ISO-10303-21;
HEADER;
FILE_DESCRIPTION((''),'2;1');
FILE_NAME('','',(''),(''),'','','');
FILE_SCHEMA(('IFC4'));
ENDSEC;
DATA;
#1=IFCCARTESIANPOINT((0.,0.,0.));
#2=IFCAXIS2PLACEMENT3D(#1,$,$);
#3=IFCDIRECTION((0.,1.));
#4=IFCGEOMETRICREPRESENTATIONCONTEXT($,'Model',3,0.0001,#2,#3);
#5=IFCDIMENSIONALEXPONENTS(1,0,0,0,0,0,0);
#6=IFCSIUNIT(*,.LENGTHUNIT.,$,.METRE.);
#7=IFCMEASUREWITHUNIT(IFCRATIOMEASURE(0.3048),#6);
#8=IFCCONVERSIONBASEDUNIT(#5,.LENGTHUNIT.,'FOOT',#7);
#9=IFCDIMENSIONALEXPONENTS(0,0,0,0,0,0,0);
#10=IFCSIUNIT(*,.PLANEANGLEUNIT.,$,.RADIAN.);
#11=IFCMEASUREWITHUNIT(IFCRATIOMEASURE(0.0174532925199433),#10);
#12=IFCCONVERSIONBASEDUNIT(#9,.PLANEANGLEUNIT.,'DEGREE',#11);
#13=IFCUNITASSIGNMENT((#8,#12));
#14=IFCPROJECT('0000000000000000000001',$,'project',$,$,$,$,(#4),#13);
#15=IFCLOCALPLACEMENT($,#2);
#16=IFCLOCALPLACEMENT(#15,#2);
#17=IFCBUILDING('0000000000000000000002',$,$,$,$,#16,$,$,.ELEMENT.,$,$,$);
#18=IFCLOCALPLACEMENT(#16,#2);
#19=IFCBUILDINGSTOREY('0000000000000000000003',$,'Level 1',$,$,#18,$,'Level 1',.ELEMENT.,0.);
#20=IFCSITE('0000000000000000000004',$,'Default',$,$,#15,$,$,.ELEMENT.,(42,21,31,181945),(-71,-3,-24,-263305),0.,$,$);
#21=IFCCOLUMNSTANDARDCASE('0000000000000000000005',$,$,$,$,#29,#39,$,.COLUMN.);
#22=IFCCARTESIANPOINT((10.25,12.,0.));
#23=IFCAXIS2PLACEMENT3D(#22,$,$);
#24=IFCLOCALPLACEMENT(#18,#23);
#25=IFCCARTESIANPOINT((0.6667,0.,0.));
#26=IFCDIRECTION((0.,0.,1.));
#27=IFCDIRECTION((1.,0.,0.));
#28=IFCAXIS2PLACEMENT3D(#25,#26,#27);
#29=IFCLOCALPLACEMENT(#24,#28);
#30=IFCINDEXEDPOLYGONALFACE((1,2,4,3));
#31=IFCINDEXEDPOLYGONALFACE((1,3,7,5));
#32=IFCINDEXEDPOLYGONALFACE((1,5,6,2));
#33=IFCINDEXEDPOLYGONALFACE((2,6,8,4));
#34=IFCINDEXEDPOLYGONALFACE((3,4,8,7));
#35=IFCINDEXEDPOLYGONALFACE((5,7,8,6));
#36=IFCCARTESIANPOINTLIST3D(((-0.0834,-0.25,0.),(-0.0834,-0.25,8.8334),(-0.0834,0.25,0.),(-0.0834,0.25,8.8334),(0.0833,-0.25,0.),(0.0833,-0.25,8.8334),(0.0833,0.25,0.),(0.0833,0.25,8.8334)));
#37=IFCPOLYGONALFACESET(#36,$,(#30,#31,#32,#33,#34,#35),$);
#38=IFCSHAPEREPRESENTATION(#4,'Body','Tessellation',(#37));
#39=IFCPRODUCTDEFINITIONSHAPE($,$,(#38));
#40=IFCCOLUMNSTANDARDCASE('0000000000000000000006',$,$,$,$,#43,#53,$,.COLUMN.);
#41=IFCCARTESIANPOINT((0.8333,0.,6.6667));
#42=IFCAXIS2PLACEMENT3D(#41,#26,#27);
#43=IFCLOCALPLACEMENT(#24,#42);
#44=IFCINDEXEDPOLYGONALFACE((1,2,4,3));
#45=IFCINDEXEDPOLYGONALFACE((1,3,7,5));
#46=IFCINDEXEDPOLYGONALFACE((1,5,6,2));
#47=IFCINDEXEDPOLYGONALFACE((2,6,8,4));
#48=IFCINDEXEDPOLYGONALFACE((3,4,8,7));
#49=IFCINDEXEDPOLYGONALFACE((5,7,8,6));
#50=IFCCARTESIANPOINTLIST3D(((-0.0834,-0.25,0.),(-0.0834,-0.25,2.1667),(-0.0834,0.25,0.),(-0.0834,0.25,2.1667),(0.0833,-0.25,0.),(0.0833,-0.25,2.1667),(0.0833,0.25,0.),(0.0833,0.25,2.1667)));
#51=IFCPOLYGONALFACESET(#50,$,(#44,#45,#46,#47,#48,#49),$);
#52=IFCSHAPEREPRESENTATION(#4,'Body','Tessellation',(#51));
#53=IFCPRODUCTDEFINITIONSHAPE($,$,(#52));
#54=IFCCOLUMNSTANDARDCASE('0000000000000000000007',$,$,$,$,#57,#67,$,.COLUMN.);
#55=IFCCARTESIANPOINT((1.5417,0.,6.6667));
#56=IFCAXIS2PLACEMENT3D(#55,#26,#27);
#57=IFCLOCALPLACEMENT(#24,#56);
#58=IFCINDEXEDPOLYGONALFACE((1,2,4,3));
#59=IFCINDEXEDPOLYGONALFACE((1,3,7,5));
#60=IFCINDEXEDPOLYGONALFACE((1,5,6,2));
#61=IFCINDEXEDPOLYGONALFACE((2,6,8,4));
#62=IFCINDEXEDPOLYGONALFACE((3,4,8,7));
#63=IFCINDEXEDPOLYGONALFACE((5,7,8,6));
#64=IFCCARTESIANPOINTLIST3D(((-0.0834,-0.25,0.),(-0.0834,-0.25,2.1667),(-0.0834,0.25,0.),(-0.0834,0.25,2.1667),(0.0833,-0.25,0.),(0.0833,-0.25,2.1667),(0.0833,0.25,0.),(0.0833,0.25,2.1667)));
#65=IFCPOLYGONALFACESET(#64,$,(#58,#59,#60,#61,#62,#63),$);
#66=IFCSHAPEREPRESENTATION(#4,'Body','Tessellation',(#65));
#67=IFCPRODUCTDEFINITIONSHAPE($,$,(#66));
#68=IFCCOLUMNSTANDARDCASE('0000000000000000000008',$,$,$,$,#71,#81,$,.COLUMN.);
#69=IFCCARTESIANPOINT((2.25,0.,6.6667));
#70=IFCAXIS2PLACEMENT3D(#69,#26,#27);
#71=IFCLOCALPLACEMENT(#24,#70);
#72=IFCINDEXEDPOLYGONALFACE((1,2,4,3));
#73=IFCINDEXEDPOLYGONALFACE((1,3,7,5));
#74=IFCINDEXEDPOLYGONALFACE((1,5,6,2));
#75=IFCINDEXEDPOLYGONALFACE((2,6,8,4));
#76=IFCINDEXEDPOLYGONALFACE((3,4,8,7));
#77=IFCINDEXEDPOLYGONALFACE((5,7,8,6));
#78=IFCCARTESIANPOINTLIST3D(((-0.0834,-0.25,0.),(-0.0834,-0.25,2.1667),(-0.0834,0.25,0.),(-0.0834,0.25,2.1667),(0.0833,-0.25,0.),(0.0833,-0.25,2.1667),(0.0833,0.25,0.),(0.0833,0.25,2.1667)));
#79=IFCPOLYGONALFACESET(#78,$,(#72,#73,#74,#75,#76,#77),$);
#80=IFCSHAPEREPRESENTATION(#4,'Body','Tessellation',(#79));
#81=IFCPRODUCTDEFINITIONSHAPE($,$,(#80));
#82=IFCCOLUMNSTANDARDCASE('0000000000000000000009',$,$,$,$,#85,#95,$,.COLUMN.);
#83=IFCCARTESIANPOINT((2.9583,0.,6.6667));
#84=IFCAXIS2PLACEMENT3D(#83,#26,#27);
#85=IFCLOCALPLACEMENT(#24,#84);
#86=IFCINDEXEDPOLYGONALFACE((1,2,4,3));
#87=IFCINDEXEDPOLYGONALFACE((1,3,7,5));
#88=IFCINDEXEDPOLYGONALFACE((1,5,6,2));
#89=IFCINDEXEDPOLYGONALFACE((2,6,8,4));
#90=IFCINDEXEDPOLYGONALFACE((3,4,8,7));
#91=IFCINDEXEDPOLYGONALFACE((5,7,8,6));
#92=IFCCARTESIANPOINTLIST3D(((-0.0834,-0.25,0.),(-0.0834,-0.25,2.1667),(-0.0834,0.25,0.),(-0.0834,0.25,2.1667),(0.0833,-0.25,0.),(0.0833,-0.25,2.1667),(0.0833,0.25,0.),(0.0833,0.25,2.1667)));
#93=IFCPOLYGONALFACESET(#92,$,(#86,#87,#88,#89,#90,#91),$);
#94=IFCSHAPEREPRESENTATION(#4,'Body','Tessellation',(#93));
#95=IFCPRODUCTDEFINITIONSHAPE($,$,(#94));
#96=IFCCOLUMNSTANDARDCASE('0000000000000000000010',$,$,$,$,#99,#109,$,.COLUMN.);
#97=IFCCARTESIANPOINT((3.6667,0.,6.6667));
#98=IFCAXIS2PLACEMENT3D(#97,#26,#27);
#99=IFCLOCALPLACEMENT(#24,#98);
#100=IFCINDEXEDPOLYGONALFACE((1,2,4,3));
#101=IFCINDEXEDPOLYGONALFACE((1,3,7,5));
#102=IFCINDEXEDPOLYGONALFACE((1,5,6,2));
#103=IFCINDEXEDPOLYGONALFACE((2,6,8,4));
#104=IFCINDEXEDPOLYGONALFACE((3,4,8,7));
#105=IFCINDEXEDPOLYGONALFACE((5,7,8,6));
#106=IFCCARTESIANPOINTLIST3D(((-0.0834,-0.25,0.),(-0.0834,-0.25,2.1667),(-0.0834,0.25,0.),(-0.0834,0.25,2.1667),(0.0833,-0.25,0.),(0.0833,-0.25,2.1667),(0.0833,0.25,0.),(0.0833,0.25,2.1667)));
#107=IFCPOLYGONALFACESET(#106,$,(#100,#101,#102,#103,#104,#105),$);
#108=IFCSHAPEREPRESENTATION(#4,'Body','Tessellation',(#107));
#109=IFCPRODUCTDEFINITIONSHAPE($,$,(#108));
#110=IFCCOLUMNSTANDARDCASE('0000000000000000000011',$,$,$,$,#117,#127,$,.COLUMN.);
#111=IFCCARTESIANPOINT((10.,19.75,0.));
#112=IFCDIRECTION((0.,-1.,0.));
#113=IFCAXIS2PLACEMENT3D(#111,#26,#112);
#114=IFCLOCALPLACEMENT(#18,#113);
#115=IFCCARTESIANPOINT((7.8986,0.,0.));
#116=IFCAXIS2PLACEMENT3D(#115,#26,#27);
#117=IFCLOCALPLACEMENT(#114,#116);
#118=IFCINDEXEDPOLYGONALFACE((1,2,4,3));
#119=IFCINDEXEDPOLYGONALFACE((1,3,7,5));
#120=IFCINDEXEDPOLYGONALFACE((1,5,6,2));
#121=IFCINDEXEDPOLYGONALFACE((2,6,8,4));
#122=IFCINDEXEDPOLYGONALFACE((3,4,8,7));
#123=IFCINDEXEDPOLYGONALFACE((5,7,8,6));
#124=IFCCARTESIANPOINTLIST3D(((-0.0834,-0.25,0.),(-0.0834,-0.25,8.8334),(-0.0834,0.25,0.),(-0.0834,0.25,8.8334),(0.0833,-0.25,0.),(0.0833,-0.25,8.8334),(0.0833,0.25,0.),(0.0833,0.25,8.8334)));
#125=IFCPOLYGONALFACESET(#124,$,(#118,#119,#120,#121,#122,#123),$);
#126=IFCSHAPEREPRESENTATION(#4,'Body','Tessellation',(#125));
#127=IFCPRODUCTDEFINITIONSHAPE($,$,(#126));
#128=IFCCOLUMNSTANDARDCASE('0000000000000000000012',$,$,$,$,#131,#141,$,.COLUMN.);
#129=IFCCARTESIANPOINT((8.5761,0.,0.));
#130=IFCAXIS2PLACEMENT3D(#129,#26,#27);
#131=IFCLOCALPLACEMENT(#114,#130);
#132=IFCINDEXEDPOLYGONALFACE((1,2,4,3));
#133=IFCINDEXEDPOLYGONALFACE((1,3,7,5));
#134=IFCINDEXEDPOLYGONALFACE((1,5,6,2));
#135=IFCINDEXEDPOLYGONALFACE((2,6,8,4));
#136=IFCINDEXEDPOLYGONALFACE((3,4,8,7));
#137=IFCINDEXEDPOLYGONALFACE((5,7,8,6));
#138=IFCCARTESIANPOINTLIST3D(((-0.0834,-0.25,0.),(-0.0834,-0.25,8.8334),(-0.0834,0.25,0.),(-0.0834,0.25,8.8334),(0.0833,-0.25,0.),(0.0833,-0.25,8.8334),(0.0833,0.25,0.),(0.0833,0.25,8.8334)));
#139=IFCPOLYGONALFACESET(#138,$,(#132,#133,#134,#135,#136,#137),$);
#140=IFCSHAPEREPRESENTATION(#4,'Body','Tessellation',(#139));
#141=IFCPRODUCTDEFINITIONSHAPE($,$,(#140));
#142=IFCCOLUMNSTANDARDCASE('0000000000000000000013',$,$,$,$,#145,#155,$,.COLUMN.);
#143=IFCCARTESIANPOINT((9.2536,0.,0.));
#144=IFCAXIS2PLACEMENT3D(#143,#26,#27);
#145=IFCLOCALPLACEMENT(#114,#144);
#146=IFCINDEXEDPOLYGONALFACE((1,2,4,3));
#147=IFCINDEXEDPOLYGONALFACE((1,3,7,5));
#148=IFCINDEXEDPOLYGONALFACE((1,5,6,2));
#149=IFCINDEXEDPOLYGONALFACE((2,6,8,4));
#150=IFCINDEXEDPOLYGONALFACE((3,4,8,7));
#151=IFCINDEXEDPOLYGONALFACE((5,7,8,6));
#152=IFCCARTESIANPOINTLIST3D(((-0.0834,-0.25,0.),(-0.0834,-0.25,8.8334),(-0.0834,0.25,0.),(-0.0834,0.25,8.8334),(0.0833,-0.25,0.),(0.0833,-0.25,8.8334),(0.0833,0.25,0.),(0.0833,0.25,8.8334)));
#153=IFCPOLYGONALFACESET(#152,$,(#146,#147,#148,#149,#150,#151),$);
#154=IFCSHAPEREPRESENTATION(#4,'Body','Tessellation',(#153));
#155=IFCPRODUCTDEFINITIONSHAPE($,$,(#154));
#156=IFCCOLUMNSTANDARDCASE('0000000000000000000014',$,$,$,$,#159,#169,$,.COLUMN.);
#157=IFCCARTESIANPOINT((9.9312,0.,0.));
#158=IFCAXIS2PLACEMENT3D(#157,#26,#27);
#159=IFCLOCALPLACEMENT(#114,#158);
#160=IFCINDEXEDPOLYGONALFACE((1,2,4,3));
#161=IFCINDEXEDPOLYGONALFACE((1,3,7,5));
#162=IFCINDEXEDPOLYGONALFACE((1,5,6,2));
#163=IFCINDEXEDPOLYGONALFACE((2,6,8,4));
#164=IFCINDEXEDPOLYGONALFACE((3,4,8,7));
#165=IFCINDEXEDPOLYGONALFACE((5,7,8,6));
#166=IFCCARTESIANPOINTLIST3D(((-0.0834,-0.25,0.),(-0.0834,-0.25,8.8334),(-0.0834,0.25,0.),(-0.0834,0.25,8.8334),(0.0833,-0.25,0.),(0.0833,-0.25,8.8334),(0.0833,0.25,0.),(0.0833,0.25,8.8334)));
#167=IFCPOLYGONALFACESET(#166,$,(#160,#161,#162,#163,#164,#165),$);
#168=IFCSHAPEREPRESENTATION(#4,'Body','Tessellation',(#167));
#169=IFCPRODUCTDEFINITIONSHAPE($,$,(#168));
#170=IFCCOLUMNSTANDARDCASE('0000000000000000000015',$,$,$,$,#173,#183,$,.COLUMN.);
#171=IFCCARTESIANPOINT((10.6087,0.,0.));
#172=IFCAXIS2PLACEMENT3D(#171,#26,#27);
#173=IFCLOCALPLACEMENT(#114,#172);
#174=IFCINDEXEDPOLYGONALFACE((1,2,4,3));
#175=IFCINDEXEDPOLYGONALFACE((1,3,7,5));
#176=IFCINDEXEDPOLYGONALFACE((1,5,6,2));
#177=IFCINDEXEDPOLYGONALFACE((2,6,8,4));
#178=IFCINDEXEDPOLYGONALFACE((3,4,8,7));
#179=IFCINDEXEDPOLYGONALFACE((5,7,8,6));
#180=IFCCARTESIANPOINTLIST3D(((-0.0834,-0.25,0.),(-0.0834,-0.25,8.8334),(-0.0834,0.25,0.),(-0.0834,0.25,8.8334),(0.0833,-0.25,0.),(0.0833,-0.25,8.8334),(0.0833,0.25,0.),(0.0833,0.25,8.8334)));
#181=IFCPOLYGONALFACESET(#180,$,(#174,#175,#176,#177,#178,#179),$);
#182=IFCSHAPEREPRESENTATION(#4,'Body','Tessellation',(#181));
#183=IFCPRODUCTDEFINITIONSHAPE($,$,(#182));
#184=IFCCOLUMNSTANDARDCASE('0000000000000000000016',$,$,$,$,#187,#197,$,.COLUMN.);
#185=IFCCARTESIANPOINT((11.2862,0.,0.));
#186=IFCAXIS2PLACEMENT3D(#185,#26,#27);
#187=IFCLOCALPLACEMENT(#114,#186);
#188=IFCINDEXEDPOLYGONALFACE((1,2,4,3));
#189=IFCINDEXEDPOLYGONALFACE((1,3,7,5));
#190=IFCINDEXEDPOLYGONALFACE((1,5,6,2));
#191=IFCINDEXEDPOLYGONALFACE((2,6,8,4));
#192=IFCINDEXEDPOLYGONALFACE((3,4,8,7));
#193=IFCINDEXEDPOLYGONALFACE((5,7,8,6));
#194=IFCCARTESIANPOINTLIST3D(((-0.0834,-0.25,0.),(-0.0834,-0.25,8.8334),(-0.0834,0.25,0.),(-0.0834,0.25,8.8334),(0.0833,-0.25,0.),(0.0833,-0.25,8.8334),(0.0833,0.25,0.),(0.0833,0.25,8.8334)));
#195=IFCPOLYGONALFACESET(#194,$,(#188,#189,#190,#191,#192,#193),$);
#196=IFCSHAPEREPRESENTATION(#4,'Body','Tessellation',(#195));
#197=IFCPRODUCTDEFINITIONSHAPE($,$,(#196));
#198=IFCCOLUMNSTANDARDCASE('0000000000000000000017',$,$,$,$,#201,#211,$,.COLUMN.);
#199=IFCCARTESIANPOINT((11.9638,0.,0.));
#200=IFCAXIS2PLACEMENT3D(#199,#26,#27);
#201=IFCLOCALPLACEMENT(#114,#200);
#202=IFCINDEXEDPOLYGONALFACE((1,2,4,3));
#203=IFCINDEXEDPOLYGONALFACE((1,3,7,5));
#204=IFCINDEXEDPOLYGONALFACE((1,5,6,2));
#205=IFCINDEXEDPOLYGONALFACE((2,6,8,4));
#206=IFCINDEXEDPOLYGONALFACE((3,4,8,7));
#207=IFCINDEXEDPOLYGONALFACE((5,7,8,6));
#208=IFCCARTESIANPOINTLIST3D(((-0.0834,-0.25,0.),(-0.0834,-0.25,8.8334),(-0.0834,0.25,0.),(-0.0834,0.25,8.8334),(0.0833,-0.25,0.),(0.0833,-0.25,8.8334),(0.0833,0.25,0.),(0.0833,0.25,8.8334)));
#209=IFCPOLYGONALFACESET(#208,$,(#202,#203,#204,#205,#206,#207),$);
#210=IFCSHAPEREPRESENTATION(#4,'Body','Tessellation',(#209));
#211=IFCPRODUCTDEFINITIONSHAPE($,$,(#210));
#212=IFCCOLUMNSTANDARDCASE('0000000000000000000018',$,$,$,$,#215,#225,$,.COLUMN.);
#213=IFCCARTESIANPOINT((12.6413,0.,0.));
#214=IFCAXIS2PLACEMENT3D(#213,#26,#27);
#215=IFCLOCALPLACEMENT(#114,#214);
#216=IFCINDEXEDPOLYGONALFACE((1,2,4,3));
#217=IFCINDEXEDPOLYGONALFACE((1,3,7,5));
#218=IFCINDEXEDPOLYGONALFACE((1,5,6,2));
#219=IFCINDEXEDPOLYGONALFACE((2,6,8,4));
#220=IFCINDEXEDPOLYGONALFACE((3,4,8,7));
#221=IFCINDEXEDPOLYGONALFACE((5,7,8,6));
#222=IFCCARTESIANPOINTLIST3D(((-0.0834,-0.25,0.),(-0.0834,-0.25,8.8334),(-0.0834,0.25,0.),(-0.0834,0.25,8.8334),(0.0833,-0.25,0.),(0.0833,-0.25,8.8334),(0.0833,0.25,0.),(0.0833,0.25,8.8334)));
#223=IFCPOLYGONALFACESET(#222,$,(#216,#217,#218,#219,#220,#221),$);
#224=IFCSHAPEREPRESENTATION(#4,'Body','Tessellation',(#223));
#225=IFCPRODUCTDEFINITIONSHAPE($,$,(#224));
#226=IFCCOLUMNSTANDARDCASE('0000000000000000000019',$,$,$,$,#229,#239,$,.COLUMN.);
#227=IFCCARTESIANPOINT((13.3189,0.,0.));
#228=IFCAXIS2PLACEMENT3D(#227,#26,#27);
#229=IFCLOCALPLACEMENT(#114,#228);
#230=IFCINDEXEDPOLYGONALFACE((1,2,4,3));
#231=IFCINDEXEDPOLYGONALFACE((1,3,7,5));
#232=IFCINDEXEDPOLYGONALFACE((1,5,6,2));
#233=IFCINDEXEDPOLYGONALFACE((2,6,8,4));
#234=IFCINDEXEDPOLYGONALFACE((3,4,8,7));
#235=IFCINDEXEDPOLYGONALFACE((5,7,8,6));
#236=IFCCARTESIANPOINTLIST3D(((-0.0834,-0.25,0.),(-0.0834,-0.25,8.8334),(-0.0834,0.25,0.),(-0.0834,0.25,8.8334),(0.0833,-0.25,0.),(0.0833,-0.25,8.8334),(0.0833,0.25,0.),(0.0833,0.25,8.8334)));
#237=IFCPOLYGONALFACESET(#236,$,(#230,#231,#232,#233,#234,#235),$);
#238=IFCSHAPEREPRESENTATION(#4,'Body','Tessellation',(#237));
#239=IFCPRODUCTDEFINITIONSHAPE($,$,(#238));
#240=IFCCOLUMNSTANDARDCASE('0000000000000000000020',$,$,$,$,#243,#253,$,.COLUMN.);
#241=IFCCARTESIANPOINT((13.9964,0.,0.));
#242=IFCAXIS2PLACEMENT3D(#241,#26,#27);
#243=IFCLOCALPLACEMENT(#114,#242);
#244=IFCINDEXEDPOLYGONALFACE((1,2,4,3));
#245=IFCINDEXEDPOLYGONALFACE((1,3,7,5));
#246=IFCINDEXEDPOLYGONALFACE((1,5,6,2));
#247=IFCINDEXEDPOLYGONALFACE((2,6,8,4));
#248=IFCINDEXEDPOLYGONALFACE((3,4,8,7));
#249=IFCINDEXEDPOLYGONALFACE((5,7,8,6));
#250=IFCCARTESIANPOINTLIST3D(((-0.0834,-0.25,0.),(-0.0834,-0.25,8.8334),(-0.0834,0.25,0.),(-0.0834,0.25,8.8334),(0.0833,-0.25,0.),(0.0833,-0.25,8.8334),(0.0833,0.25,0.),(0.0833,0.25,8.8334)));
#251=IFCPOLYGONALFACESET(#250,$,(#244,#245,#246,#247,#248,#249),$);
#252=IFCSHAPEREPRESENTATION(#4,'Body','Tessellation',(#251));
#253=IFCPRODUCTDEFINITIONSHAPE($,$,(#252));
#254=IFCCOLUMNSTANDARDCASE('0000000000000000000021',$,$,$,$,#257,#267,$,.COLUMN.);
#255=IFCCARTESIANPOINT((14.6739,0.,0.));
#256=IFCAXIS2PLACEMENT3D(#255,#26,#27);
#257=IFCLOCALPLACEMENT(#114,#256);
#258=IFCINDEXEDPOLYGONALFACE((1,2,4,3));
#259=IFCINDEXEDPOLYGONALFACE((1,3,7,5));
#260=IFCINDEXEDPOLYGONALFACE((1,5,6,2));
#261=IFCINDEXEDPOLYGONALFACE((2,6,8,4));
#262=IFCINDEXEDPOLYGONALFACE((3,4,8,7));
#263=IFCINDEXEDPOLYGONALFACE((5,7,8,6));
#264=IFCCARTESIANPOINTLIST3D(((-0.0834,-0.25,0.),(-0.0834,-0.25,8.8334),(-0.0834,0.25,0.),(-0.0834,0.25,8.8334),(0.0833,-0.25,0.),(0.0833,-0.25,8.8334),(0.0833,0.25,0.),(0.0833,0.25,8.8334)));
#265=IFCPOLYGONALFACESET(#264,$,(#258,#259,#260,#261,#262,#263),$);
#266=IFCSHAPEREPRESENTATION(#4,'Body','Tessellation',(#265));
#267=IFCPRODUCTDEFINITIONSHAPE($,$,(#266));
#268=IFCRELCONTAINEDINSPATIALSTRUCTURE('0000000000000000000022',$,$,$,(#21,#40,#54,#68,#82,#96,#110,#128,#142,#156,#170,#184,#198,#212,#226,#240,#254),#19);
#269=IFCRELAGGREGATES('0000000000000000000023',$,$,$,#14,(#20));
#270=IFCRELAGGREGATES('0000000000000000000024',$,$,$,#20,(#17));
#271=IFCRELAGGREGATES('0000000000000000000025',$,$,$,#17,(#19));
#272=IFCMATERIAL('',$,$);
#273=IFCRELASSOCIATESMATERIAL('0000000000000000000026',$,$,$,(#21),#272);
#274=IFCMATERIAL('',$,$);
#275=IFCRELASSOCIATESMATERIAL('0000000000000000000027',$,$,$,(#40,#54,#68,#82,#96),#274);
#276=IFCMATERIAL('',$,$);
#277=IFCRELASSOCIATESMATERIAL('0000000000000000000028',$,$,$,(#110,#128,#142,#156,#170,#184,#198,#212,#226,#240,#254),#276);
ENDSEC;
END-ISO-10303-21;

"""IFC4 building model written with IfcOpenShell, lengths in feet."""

from ifc_helpers import new_model, entity, si_unit, converted_unit, direction, frame, origin, place, context, project, spatial, rectangle, extrude, material, element, save


model = new_model("IFC4")

# Units and contexts
model_context = context("Model", 3, precision=0.0001, world=origin(), true_north=direction((0.0, 1.0)))
ifc_project = project(units=[converted_unit("LENGTHUNIT", "FOOT", entity("IfcRatioMeasure", 0.3048), si_unit("LENGTHUNIT", "METRE"), dimensions=[1, 0, 0, 0, 0, 0, 0]), converted_unit("PLANEANGLEUNIT", "DEGREE", entity("IfcRatioMeasure", 0.0174532925199433), si_unit("PLANEANGLEUNIT", "RADIAN"), dimensions=[0, 0, 0, 0, 0, 0, 0])], contexts=[model_context])

# Site, building, storey
site_placement = place(None, origin())
site = spatial("IfcSite", under=ifc_project, at=site_placement, Name="Default", CompositionType="ELEMENT", RefLatitude=(42, 21, 31, 181945), RefLongitude=(-71, -3, -24, -263305), RefElevation=0.0)
building_placement = place(site_placement, origin())
building = spatial("IfcBuilding", under=site, at=building_placement, CompositionType="ELEMENT")
storey_placement = place(building_placement, origin())
storey = spatial("IfcBuildingStorey", under=building, at=storey_placement, Name="Level 1", LongName="Level 1", CompositionType="ELEMENT", Elevation=0.0)

# Columns
ifc_material_1 = material(Name="")
placement_1 = place(storey_placement, frame((10.25, 12.0, 0.0)))
for number, where, z_axis, x_axis in (
    (1, (0.6667, 0.0, 0.0), (0.0, 0.0, 1.0), (1.0, 0.0, 0.0)),
):
    element("IfcColumnStandardCase", number, at=place(placement_1, frame(where, z_axis=z_axis, x_axis=x_axis)), inside=storey, material=ifc_material_1, PredefinedType="COLUMN", context=model_context, shape_type="SweptSolid", body=[
        extrude(rectangle(XDim=0.1667, YDim=0.5), origin(), (0.0, 0.0, 1.0), 8.8334),
    ])
ifc_material_2 = material(Name="")
ifc_material_3 = material(Name="")
for number, where, z_axis, x_axis in (
    (2, (0.8333, 0.0, 6.6667), (0.0, 0.0, 1.0), (1.0, 0.0, 0.0)),
    (3, (1.5417, 0.0, 6.6667), (0.0, 0.0, 1.0), (1.0, 0.0, 0.0)),
    (4, (2.25, 0.0, 6.6667), (0.0, 0.0, 1.0), (1.0, 0.0, 0.0)),
    (5, (2.9583, 0.0, 6.6667), (0.0, 0.0, 1.0), (1.0, 0.0, 0.0)),
    (6, (3.6667, 0.0, 6.6667), (0.0, 0.0, 1.0), (1.0, 0.0, 0.0)),
):
    element("IfcColumnStandardCase", number, at=place(placement_1, frame(where, z_axis=z_axis, x_axis=x_axis)), inside=storey, material=ifc_material_3, PredefinedType="COLUMN", context=model_context, shape_type="SweptSolid", body=[
        extrude(rectangle(XDim=0.1667, YDim=0.5), origin(), (0.0, 0.0, 1.0), 2.1667),
    ])
placement_2 = place(storey_placement, frame((10.0, 19.75, 0.0), z_axis=(0.0, 0.0, 1.0), x_axis=(0.0, -1.0, 0.0)))
for number, where, z_axis, x_axis in (
    (7, (7.8986, 0.0, 0.0), (0.0, 0.0, 1.0), (1.0, 0.0, 0.0)),
    (8, (8.5761, 0.0, 0.0), (0.0, 0.0, 1.0), (1.0, 0.0, 0.0)),
    (9, (9.2536, 0.0, 0.0), (0.0, 0.0, 1.0), (1.0, 0.0, 0.0)),
    (10, (9.9312, 0.0, 0.0), (0.0, 0.0, 1.0), (1.0, 0.0, 0.0)),
    (11, (10.6087, 0.0, 0.0), (0.0, 0.0, 1.0), (1.0, 0.0, 0.0)),
    (12, (11.2862, 0.0, 0.0), (0.0, 0.0, 1.0), (1.0, 0.0, 0.0)),
    (13, (11.9638, 0.0, 0.0), (0.0, 0.0, 1.0), (1.0, 0.0, 0.0)),
    (14, (12.6413, 0.0, 0.0), (0.0, 0.0, 1.0), (1.0, 0.0, 0.0)),
    (15, (13.3189, 0.0, 0.0), (0.0, 0.0, 1.0), (1.0, 0.0, 0.0)),
    (16, (13.9964, 0.0, 0.0), (0.0, 0.0, 1.0), (1.0, 0.0, 0.0)),
    (17, (14.6739, 0.0, 0.0), (0.0, 0.0, 1.0), (1.0, 0.0, 0.0)),
):
    element("IfcColumnStandardCase", number, at=place(placement_2, frame(where, z_axis=z_axis, x_axis=x_axis)), inside=storey, material=ifc_material_2, PredefinedType="COLUMN", context=model_context, shape_type="SweptSolid", body=[
        extrude(rectangle(XDim=0.1667, YDim=0.5), origin(), (0.0, 0.0, 1.0), 8.8334),
    ])

save(model, "model.ifc")
